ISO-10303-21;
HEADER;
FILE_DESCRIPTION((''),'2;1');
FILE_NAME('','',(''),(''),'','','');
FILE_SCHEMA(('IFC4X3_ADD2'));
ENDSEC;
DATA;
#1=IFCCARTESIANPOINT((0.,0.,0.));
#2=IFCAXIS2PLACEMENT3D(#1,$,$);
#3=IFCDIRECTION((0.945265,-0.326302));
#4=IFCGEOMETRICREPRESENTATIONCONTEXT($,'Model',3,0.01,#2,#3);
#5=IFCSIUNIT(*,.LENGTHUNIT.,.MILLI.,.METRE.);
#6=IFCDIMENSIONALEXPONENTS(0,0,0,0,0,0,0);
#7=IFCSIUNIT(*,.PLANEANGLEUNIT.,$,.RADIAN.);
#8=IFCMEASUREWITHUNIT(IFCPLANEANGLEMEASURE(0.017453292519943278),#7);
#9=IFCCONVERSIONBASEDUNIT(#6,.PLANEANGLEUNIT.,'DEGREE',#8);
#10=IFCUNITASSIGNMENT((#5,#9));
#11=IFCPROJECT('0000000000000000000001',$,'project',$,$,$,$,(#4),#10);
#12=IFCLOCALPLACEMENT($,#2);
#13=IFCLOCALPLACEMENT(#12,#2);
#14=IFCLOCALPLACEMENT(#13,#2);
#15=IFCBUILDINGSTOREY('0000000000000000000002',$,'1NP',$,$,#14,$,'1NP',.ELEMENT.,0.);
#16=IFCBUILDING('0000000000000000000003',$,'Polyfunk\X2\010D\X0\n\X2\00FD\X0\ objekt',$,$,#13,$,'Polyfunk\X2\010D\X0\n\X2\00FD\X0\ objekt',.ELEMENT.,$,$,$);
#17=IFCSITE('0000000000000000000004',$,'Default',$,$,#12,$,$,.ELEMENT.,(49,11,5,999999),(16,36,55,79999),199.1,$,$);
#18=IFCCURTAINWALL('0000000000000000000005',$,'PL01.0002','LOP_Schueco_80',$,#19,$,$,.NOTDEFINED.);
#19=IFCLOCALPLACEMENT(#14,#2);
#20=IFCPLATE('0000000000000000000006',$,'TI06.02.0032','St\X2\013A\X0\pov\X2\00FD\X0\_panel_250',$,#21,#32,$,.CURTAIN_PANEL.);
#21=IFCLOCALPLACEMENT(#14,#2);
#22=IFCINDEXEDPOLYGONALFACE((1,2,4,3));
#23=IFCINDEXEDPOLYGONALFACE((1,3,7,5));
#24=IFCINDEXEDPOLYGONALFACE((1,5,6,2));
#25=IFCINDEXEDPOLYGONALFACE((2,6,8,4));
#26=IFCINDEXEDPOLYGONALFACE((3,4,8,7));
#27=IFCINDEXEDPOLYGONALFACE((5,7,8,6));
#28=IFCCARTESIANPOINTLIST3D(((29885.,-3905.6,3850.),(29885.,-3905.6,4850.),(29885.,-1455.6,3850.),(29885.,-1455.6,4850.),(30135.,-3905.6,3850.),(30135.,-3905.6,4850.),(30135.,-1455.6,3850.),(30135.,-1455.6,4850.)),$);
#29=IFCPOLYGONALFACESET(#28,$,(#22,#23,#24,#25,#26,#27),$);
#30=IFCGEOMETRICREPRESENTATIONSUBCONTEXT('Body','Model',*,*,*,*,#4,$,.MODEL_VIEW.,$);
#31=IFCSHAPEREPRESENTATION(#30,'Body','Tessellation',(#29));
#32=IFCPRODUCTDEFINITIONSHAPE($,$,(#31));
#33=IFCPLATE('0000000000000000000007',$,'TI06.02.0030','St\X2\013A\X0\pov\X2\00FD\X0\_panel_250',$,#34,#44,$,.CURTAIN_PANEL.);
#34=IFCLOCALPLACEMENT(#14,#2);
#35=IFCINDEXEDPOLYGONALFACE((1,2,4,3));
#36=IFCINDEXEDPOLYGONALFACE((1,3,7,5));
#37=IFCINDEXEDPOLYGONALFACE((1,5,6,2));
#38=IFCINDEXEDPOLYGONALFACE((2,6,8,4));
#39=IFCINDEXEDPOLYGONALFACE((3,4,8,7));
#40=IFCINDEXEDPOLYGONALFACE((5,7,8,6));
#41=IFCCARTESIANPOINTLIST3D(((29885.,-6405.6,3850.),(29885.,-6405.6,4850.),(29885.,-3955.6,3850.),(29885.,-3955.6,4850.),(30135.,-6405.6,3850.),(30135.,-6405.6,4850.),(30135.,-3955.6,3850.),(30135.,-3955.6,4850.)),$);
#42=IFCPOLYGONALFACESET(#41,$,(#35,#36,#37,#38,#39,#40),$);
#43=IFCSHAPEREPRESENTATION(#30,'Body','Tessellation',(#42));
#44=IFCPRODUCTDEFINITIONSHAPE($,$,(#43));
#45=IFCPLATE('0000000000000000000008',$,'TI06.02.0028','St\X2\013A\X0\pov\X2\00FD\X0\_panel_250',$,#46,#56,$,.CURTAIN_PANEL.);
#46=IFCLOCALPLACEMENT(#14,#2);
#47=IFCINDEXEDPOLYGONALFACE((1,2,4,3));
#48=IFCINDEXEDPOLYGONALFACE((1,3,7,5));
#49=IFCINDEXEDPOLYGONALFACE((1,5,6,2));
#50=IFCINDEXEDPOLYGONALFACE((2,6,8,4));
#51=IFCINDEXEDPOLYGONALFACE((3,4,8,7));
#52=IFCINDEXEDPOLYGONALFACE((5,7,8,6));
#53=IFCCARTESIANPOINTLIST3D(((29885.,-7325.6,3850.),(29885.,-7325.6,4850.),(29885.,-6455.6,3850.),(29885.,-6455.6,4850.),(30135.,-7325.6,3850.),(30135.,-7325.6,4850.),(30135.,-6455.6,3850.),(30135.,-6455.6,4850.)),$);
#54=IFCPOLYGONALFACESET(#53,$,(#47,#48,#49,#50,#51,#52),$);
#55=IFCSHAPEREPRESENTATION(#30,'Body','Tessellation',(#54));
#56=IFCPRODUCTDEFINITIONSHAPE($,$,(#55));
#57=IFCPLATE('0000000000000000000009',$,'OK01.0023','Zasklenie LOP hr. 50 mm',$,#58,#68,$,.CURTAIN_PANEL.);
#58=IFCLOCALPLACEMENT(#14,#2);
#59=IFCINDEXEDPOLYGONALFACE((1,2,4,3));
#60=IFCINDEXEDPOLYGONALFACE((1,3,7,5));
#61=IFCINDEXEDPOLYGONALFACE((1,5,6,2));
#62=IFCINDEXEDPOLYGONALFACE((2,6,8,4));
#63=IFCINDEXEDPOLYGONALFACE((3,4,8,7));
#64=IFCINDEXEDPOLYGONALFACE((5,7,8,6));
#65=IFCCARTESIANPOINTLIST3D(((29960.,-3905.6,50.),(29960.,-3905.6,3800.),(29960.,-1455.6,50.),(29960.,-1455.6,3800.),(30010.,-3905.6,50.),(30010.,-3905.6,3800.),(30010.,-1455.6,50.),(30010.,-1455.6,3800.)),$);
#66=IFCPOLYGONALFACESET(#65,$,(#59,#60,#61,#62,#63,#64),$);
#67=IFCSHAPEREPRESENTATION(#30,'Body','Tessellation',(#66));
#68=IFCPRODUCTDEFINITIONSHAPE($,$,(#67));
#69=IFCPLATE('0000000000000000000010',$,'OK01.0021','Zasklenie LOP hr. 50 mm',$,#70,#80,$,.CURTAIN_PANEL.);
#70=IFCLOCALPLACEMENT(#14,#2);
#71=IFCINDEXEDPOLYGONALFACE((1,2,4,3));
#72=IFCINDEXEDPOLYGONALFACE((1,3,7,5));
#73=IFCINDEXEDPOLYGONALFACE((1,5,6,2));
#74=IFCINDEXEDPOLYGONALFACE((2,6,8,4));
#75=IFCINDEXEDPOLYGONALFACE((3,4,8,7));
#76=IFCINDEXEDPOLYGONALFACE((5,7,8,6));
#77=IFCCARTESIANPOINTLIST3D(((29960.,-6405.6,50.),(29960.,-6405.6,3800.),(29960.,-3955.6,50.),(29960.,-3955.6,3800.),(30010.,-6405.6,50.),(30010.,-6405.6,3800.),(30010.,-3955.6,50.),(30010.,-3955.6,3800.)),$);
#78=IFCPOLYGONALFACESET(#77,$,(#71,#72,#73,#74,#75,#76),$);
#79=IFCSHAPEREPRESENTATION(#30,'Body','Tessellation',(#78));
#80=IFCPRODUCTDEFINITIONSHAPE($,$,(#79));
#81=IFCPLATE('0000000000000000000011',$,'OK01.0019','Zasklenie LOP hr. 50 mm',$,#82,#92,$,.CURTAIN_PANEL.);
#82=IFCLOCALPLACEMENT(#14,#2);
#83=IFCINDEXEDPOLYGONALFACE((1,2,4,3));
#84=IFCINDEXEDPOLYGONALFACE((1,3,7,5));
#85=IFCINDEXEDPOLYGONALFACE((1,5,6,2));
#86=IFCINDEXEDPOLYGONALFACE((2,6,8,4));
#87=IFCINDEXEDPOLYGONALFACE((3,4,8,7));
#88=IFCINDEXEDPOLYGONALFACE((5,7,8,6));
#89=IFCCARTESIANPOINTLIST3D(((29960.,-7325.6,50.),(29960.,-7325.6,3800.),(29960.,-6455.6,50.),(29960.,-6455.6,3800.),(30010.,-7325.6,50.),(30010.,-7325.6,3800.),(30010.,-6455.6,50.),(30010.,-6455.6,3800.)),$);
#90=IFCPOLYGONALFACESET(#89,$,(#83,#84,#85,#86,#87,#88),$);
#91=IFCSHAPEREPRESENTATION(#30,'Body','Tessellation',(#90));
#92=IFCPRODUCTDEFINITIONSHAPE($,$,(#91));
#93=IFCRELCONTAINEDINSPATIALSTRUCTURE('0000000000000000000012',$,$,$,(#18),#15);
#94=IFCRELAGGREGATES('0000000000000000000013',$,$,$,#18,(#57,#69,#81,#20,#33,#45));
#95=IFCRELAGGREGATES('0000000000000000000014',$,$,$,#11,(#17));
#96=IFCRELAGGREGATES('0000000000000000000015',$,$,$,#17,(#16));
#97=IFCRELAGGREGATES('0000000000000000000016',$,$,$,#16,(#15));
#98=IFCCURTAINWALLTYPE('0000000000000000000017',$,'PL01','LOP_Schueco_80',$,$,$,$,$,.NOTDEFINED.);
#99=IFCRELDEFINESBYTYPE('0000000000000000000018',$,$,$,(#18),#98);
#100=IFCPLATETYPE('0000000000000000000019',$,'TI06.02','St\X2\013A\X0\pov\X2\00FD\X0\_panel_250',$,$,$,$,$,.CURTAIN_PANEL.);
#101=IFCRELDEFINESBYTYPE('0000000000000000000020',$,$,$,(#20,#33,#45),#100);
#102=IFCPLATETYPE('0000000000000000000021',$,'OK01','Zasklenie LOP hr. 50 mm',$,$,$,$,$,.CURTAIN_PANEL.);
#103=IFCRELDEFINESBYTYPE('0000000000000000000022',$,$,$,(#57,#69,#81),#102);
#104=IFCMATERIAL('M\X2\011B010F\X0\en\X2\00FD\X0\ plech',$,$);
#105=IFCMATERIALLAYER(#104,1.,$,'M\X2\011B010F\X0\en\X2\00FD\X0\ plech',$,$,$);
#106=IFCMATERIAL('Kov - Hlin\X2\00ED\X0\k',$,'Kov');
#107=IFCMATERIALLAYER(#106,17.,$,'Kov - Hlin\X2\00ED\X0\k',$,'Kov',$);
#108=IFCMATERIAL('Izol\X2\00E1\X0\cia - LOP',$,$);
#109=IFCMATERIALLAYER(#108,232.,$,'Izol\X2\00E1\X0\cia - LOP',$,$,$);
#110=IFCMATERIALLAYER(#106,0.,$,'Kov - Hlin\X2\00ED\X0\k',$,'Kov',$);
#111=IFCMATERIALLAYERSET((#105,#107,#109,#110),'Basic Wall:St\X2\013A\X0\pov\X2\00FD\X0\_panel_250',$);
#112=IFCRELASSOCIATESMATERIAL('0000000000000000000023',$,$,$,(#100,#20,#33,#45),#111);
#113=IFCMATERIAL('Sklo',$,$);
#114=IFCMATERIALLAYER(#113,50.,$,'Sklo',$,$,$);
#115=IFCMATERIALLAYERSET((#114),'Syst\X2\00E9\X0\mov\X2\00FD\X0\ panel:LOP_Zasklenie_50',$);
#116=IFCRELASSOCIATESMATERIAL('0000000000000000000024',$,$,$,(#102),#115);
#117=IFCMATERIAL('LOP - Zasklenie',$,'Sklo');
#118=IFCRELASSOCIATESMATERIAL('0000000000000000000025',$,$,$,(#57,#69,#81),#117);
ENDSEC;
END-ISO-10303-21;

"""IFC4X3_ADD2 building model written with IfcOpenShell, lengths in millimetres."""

from ifc_helpers import new_model, entity, si_unit, converted_unit, direction, frame, frame_2d, origin, origin_2d_with_axis, place, context, subcontext, project, spatial, rectangle, extrude, source, transform, mapped, material, layer, layer_set, layer_usage, type_object, type_shapes, element, aggregate, save


model = new_model("IFC4X3_ADD2")

# Units and contexts
model_context = context("Model", 3, precision=0.01, world=origin(), true_north=direction((0.945265, -0.326302)))
body_context = subcontext(model_context, "Body", "Model", "MODEL_VIEW")
ifc_project = project(units=[si_unit("LENGTHUNIT", "METRE", prefix="MILLI"), converted_unit("PLANEANGLEUNIT", "DEGREE", entity("IfcPlaneAngleMeasure", 0.017453292519943278), si_unit("PLANEANGLEUNIT", "RADIAN"), dimensions=[0, 0, 0, 0, 0, 0, 0])], contexts=[model_context])

# Site, building, storey
site_placement = place(None, origin())
site = spatial("IfcSite", under=ifc_project, at=site_placement, Name="Default", CompositionType="ELEMENT", RefLatitude=(49, 11, 5, 999999), RefLongitude=(16, 36, 55, 79999), RefElevation=199.1)
building_placement = place(site_placement, origin())
building = spatial("IfcBuilding", under=site, at=building_placement, Name="Polyfunkčný objekt", LongName="Polyfunkčný objekt", CompositionType="ELEMENT")
storey_placement = place(building_placement, origin())
storey = spatial("IfcBuildingStorey", under=building, at=storey_placement, Name="1NP", LongName="1NP", CompositionType="ELEMENT", Elevation=0.0)

# Curtain wall
curtain_wall_type = type_object("IfcCurtainWallType", Name="PL01", Description="LOP_Schueco_80", PredefinedType="NOTDEFINED")
curtain_wall_1_placement = place(storey_placement, origin())
curtain_wall_1 = element("IfcCurtainWall", 1, at=curtain_wall_1_placement, inside=storey, type_object=curtain_wall_type, Name="PL01.0002", Description="LOP_Schueco_80", PredefinedType="NOTDEFINED")

# Plates
ifc_material_1 = material(Name="Měďený plech")
ifc_layer_1 = layer(ifc_material_1, 1.0, Name="Měďený plech")
ifc_material_2 = material(Name="Kov - Hliník", Category="Kov")
ifc_layer_2 = layer(ifc_material_2, 17.0, Name="Kov - Hliník", Category="Kov")
ifc_material_3 = material(Name="Izolácia - LOP")
ifc_layer_3 = layer(ifc_material_3, 232.0, Name="Izolácia - LOP")
ifc_layer_4 = layer(ifc_material_2, 0.0, Name="Kov - Hliník", Category="Kov")
ifc_layer_set_1 = layer_set([ifc_layer_1, ifc_layer_2, ifc_layer_3, ifc_layer_4], Name="Basic Wall:Stĺpový_panel_250")
plate_type_1 = type_object("IfcPlateType", Name="TI06.02", Description="Stĺpový_panel_250", PredefinedType="CURTAIN_PANEL", material=ifc_layer_set_1)
ifc_layer_usage_1 = layer_usage(ifc_layer_set_1, "AXIS2", "POSITIVE", -125.0)
plate_1_placement = place(storey_placement, frame((30010.0, -1455.6, 3850.0), z_axis=(0.0, 0.0, 1.0), x_axis=(0.0, -1.0, 0.0)))
plate_1 = element("IfcPlate", 2, at=plate_1_placement, type_object=plate_type_1, material=ifc_layer_usage_1, Name="TI06.02.0032", Description="Stĺpový_panel_250", PredefinedType="CURTAIN_PANEL", context=body_context, shape_type="SweptSolid", body=[
    extrude(rectangle(XDim=250.0, YDim=2450.0, at=frame_2d((0.0, 0.0), x_axis=(1.0, 0.0))), frame((1225.0, 0.0, 0.0), z_axis=(0.0, 0.0, 1.0), x_axis=(0.0, 1.0, 0.0)), (0.0, 0.0, 1.0), 1000.0),
])
ifc_layer_usage_2 = layer_usage(ifc_layer_set_1, "AXIS2", "POSITIVE", -125.0)
plate_2_placement = place(storey_placement, frame((30010.0, -3955.6, 3850.0), z_axis=(0.0, 0.0, 1.0), x_axis=(0.0, -1.0, 0.0)))
plate_2 = element("IfcPlate", 3, at=plate_2_placement, type_object=plate_type_1, material=ifc_layer_usage_2, Name="TI06.02.0030", Description="Stĺpový_panel_250", PredefinedType="CURTAIN_PANEL", context=body_context, shape_type="SweptSolid", body=[
    extrude(rectangle(XDim=250.0, YDim=2450.0, at=origin_2d_with_axis()), frame((1225.0, 0.0, 0.0), z_axis=(0.0, 0.0, 1.0), x_axis=(0.0, 1.0, 0.0)), (0.0, 0.0, 1.0), 1000.0),
])
ifc_layer_usage_3 = layer_usage(ifc_layer_set_1, "AXIS2", "POSITIVE", -125.0)
plate_3_placement = place(storey_placement, frame((30010.0, -6455.6, 3850.0), z_axis=(0.0, 0.0, 1.0), x_axis=(0.0, -1.0, 0.0)))
plate_3 = element("IfcPlate", 4, at=plate_3_placement, type_object=plate_type_1, material=ifc_layer_usage_3, Name="TI06.02.0028", Description="Stĺpový_panel_250", PredefinedType="CURTAIN_PANEL", context=body_context, shape_type="SweptSolid", body=[
    extrude(rectangle(XDim=250.0, YDim=870.0, at=frame_2d((0.0, 0.0), x_axis=(1.0, 0.0))), frame((435.0, 0.0, 0.0), z_axis=(0.0, 0.0, 1.0), x_axis=(0.0, 1.0, 0.0)), (0.0, 0.0, 1.0), 1000.0),
])
ifc_material_4 = material(Name="LOP - Zasklenie", Category="Sklo")
ifc_material_5 = material(Name="Sklo")
ifc_layer_5 = layer(ifc_material_5, 50.0, Name="Sklo")
ifc_layer_set_2 = layer_set([ifc_layer_5], Name="Systémový panel:LOP_Zasklenie_50")
plate_type_2 = type_object("IfcPlateType", Name="OK01", Description="Zasklenie LOP hr. 50 mm", PredefinedType="CURTAIN_PANEL", material=ifc_layer_set_2)
shared_shape_1 = source(origin(), body_context, "Body", "SweptSolid", [
    extrude(rectangle(XDim=3750.0, YDim=2450.0, at=frame_2d((-141.7, 0.0), x_axis=(1.0, 0.0))), frame((0.0, -50.0, 2016.7), z_axis=(0.0, 1.0, 0.0), x_axis=(0.0, 0.0, 1.0)), (0.0, 0.0, 1.0), 50.0),
])
plate_4_placement = place(curtain_wall_1_placement, frame((30010.0, -2680.6, 50.0), z_axis=(0.0, 0.0, 1.0), x_axis=(0.0, -1.0, 0.0)))
plate_4 = element("IfcPlate", 5, at=plate_4_placement, type_object=plate_type_2, material=ifc_material_4, Name="OK01.0023", Description="Zasklenie LOP hr. 50 mm", PredefinedType="CURTAIN_PANEL", context=body_context, shape_type="MappedRepresentation", body=[
    mapped(shared_shape_1, transform((0.0, 0.0, 0.0), scale=1.0)),
])
plate_5_placement = place(curtain_wall_1_placement, frame((30010.0, -5180.6, 50.0), z_axis=(0.0, 0.0, 1.0), x_axis=(0.0, -1.0, 0.0)))
plate_5 = element("IfcPlate", 6, at=plate_5_placement, type_object=plate_type_2, material=ifc_material_4, Name="OK01.0021", Description="Zasklenie LOP hr. 50 mm", PredefinedType="CURTAIN_PANEL", context=body_context, shape_type="MappedRepresentation", body=[
    mapped(shared_shape_1, transform((0.0, 0.0, 0.0), scale=1.0)),
])
shared_shape_2 = source(origin(), body_context, "Body", "SweptSolid", [
    extrude(rectangle(XDim=3750.0, YDim=870.0, at=frame_2d((-141.7, 0.0), x_axis=(1.0, 0.0))), frame((0.0, -50.0, 2016.7), z_axis=(0.0, 1.0, 0.0), x_axis=(0.0, 0.0, 1.0)), (0.0, 0.0, 1.0), 50.0),
])
type_shapes(plate_type_2, [shared_shape_1, shared_shape_2])
plate_6_placement = place(curtain_wall_1_placement, frame((30010.0, -6890.6, 50.0), z_axis=(0.0, 0.0, 1.0), x_axis=(0.0, -1.0, 0.0)))
plate_6 = element("IfcPlate", 7, at=plate_6_placement, type_object=plate_type_2, material=ifc_material_4, Name="OK01.0019", Description="Zasklenie LOP hr. 50 mm", PredefinedType="CURTAIN_PANEL", context=body_context, shape_type="MappedRepresentation", body=[
    mapped(shared_shape_2, transform((0.0, 0.0, 0.0), scale=1.0)),
])
aggregate(curtain_wall_1, [plate_4, plate_5, plate_6, plate_1, plate_2, plate_3])

save(model, "model.ifc")
